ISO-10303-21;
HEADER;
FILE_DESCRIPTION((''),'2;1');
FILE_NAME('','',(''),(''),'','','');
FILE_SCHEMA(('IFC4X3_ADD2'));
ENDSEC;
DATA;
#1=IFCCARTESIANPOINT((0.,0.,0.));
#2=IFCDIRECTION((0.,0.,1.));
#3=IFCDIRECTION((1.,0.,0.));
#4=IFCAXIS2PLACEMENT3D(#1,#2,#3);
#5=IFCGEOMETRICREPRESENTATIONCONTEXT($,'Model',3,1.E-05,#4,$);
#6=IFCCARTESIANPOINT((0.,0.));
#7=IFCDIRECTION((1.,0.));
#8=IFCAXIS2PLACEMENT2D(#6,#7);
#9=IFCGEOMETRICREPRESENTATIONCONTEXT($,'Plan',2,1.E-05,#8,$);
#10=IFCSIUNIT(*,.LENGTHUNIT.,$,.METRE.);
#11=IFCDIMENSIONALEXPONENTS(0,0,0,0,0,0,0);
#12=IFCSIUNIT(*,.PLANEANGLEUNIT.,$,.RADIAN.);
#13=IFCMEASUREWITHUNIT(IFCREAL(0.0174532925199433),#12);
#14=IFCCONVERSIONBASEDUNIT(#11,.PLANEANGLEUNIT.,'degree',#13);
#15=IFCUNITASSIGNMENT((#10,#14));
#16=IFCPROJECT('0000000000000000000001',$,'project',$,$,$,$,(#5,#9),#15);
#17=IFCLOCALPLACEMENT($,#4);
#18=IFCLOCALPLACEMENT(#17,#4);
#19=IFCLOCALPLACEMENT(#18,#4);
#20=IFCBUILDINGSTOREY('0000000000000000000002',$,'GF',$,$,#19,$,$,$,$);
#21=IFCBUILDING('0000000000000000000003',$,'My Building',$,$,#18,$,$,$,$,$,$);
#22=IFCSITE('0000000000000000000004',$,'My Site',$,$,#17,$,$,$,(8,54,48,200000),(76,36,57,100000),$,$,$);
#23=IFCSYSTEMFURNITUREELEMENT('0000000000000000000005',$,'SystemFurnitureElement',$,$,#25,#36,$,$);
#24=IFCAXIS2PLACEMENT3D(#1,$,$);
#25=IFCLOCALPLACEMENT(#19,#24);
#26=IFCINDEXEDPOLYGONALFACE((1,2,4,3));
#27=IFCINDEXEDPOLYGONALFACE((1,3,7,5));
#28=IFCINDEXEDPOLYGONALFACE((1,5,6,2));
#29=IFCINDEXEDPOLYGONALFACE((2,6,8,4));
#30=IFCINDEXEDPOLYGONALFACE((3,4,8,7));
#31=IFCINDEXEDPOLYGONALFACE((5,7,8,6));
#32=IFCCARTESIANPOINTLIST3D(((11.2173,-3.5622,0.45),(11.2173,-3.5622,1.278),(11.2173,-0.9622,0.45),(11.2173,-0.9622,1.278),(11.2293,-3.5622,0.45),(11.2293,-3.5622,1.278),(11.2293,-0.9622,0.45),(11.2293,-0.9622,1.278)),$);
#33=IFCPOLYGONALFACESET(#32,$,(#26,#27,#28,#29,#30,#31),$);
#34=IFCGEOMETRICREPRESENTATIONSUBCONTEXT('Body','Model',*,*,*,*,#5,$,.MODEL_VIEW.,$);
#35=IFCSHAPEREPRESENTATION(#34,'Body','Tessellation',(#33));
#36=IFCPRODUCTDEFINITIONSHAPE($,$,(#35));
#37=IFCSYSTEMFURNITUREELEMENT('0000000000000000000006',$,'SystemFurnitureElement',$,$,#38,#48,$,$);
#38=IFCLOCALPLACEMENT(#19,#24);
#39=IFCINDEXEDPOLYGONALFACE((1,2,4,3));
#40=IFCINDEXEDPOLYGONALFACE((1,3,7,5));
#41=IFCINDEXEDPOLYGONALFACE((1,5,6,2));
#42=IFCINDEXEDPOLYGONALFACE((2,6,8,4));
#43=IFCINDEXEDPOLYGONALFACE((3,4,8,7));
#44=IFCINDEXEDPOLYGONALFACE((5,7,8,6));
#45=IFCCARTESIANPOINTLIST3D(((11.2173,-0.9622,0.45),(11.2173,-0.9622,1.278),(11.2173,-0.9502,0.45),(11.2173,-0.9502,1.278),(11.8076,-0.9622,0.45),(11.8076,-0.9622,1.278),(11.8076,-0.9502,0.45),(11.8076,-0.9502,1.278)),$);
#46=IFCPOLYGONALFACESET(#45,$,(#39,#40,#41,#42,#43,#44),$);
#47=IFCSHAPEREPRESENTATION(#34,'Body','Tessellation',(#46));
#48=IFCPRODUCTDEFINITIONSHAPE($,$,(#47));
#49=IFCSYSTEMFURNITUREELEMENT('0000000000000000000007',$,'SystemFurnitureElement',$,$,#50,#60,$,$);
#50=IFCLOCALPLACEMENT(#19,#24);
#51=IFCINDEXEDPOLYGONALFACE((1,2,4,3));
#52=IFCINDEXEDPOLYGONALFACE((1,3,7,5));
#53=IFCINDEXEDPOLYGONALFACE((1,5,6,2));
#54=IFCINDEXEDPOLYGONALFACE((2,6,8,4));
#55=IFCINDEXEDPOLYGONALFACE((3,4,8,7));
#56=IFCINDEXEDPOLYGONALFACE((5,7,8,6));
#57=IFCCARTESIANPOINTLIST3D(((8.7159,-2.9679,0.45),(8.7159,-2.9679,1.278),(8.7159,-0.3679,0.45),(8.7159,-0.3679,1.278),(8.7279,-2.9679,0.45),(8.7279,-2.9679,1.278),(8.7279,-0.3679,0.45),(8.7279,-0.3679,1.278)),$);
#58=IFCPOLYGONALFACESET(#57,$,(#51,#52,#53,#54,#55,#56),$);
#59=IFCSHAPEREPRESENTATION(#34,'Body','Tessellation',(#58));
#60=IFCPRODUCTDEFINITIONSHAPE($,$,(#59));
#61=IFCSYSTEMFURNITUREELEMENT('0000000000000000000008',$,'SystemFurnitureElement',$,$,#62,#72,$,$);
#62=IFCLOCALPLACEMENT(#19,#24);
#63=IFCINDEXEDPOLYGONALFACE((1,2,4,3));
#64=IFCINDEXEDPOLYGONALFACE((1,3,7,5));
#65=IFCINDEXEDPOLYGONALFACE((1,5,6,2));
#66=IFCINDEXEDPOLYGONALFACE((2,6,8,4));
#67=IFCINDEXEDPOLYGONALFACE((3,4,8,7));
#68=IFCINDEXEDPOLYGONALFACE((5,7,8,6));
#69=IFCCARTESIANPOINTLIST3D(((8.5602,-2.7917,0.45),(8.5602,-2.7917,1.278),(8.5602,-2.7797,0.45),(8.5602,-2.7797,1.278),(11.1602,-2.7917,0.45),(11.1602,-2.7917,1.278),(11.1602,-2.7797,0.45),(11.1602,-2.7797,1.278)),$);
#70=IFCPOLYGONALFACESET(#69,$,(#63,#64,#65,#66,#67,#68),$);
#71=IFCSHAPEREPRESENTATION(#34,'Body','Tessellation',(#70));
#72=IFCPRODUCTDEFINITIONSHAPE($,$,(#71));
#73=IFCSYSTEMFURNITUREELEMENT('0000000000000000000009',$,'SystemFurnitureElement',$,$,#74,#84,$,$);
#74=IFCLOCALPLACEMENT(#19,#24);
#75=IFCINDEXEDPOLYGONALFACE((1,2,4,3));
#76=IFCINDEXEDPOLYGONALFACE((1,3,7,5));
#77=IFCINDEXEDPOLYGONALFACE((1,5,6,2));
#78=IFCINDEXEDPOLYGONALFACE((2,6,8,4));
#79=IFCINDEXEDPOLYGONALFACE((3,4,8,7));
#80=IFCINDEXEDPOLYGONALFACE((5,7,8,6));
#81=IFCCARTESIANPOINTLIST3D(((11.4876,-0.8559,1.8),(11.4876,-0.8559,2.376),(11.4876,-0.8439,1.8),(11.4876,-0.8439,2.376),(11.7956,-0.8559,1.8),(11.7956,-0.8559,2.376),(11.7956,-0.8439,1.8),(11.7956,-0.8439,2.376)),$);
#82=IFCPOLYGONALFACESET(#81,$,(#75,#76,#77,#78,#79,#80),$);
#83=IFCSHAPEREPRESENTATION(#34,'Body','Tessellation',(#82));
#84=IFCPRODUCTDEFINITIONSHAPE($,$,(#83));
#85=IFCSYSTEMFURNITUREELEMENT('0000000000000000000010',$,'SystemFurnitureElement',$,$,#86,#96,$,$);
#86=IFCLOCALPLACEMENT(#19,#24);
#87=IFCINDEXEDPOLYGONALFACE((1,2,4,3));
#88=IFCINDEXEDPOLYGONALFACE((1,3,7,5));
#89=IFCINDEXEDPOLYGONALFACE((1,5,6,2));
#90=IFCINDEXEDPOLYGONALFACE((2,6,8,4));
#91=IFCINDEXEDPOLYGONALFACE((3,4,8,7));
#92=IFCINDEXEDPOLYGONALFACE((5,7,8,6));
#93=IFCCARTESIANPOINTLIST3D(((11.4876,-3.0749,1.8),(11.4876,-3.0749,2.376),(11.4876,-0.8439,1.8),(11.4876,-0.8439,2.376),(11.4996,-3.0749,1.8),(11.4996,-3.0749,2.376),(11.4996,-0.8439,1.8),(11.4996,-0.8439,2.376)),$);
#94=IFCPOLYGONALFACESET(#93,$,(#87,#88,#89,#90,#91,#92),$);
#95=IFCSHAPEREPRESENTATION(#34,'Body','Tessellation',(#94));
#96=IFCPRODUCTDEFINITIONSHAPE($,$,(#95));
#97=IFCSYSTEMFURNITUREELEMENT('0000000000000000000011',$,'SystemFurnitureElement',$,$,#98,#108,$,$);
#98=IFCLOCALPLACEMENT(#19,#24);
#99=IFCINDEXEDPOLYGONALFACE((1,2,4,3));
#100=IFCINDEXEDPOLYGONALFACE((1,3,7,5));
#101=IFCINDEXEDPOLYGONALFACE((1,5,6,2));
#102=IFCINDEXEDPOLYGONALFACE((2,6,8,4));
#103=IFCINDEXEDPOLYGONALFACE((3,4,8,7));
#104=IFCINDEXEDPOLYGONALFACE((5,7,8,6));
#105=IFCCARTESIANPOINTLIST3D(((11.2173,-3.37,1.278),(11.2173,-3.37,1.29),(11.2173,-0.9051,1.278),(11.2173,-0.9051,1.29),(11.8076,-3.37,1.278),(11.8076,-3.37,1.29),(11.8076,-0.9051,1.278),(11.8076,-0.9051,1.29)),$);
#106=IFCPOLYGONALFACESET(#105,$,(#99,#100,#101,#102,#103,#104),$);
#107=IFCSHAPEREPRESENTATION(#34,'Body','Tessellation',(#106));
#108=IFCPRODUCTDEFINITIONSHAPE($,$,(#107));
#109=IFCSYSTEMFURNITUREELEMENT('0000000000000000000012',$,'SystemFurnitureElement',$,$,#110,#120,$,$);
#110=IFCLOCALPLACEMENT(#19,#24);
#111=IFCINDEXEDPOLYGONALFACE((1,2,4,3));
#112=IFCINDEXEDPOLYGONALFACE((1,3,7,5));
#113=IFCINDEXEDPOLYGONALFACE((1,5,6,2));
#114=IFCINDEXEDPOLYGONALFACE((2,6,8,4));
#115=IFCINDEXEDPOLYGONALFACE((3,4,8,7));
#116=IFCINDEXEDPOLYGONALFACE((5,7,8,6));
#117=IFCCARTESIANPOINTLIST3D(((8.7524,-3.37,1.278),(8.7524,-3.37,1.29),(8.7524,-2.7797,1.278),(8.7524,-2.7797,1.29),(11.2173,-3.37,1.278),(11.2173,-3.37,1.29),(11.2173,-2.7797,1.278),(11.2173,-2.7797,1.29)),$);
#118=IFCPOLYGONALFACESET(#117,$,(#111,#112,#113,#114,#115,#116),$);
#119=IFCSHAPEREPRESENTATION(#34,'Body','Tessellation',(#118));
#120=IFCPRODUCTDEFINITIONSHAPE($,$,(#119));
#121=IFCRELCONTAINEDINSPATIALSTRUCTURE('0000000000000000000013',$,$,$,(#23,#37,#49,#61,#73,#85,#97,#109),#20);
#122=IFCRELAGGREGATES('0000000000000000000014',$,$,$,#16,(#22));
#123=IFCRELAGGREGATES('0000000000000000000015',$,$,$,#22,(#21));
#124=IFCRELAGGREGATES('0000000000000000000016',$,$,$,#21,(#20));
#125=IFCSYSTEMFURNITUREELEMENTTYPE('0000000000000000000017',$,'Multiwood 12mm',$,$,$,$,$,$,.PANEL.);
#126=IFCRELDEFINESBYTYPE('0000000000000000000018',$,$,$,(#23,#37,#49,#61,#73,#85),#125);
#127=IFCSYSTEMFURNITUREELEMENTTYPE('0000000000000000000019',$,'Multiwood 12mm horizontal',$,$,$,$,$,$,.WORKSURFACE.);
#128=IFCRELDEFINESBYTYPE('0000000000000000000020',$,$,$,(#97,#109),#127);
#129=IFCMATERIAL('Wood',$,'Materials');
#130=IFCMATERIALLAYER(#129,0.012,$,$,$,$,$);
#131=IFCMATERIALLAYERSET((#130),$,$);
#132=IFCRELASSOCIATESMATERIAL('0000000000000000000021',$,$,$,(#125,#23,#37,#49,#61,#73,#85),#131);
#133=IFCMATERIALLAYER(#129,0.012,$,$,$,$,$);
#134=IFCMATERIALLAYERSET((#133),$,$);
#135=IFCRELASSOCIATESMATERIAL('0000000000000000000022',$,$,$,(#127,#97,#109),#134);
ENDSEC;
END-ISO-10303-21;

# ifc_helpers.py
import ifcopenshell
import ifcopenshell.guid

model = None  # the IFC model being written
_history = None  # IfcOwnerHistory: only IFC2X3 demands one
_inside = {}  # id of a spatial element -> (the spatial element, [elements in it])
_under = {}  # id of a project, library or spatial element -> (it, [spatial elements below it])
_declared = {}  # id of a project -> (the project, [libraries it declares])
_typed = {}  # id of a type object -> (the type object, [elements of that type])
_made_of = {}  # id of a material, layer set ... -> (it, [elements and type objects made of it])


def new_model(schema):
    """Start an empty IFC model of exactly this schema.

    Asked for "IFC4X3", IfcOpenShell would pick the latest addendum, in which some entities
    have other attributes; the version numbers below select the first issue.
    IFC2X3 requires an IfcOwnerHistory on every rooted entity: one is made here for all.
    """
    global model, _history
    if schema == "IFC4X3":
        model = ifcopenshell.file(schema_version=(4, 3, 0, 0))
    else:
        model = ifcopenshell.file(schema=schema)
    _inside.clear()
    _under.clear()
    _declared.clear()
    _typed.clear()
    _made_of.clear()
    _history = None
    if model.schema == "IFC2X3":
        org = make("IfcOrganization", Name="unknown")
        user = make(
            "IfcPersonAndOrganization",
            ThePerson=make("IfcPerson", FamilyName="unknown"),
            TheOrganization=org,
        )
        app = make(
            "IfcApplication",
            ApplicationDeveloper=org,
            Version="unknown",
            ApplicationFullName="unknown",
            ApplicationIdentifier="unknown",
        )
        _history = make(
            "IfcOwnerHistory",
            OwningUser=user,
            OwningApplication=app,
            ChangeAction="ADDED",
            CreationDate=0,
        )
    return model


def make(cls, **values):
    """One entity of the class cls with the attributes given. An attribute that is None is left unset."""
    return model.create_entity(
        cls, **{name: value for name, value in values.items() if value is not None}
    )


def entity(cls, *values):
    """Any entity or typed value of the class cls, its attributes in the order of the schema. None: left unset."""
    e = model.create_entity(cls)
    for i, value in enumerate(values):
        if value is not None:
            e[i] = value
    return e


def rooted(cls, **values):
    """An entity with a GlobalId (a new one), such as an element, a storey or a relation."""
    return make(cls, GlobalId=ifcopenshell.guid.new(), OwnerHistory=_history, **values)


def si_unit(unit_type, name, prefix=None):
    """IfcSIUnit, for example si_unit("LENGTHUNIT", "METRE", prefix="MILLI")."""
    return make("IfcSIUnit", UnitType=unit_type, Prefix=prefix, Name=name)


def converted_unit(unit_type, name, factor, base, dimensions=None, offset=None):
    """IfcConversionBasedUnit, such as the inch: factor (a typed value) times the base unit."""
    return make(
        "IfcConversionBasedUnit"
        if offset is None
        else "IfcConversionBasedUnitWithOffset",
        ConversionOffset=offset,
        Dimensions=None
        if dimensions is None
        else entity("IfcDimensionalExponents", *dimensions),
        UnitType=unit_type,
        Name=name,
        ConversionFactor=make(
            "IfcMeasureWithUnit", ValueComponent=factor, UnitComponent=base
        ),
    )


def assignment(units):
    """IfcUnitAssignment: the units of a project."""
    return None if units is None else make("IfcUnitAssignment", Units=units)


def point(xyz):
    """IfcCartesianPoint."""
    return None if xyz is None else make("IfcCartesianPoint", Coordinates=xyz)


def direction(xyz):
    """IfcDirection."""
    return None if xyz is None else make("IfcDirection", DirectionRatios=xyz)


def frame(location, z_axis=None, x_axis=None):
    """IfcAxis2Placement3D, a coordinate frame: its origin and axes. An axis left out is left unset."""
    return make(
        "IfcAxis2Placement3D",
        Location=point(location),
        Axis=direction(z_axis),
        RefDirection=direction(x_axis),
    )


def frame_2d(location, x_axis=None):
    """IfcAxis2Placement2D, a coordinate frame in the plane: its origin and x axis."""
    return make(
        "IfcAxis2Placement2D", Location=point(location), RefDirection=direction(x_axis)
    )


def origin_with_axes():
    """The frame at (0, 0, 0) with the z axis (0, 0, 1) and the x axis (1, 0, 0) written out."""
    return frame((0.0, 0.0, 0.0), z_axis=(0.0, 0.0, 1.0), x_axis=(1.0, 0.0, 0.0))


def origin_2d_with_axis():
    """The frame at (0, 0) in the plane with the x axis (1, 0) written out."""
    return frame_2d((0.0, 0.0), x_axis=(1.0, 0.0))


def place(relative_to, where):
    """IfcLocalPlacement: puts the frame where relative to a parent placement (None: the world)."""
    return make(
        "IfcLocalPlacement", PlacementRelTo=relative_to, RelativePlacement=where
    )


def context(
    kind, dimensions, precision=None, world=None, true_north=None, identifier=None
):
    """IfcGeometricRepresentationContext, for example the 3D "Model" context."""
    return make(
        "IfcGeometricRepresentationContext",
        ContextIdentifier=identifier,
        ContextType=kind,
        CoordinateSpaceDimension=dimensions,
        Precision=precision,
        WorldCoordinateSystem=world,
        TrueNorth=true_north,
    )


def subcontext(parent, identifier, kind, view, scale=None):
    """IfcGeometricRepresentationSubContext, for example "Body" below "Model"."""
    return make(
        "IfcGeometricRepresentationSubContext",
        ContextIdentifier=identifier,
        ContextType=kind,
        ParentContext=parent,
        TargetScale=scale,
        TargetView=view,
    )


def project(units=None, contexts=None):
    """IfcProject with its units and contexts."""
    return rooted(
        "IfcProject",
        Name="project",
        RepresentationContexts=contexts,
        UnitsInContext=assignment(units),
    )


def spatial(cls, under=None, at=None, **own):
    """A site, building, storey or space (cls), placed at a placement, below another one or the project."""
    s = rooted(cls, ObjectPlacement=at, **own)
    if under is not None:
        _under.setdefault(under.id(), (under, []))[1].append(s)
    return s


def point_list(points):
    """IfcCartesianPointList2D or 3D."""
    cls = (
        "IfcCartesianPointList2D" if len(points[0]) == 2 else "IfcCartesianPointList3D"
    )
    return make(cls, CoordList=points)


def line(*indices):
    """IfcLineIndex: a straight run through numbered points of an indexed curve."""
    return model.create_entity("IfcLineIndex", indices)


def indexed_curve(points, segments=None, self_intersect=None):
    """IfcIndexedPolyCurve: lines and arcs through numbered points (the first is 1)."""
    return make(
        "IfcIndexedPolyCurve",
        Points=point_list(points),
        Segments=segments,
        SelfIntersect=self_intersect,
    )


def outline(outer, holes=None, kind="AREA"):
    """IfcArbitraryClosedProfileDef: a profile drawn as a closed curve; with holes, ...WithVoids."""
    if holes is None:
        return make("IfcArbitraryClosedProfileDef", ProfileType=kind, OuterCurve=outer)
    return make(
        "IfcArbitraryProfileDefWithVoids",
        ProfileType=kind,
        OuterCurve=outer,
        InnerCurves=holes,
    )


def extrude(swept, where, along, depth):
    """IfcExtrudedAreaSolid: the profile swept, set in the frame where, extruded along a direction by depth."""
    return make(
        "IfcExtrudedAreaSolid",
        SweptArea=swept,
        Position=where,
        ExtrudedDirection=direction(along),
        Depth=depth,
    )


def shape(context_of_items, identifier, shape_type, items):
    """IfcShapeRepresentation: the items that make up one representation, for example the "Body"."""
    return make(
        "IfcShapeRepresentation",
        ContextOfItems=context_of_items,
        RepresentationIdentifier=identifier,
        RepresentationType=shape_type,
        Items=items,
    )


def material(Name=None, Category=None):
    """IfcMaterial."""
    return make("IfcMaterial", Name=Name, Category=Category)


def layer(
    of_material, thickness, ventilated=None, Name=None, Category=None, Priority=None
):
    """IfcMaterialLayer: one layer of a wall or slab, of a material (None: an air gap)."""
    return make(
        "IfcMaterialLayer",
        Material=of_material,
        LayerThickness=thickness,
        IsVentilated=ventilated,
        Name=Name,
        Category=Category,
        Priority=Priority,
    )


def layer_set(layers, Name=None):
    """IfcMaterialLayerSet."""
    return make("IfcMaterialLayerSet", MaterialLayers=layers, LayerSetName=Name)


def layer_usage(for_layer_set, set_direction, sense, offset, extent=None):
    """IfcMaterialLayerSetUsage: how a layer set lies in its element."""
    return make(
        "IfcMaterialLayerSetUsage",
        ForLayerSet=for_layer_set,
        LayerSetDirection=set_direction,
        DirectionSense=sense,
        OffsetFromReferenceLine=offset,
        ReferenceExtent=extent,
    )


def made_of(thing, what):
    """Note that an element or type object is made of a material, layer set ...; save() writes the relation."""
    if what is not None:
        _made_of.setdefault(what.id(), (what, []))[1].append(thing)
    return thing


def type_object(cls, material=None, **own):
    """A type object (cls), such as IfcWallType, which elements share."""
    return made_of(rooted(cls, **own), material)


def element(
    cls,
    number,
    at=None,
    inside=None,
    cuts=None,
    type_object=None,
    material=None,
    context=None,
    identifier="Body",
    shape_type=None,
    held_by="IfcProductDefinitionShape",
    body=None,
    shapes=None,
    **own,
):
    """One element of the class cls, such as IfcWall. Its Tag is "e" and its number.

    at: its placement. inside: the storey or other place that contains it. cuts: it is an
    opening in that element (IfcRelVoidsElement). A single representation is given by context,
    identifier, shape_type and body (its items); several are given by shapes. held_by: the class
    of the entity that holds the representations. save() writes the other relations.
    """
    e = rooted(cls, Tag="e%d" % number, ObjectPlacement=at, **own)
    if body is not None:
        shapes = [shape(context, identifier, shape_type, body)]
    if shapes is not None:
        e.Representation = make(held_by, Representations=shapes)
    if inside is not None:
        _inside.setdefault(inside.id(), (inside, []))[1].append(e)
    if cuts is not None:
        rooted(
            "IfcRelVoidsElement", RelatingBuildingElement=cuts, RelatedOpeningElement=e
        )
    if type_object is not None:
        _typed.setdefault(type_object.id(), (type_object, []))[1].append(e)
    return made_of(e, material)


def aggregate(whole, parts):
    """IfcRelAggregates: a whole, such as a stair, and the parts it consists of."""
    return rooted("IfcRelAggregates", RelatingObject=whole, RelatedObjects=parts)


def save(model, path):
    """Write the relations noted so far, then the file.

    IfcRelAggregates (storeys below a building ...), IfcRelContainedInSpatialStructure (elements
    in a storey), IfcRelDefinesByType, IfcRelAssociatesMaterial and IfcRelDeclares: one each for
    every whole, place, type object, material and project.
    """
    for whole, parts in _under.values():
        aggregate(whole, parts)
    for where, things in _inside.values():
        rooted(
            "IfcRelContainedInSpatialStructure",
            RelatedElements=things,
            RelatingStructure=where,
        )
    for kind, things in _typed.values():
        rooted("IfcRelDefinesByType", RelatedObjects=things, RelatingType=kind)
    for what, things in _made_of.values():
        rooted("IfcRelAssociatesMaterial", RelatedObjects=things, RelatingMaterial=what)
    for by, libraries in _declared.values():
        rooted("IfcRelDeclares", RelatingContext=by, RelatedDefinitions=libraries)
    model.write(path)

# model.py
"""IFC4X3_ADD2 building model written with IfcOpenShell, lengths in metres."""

from ifc_helpers import new_model, entity, si_unit, converted_unit, frame, origin_with_axes, origin_2d_with_axis, place, context, subcontext, project, spatial, line, indexed_curve, outline, extrude, material, layer, layer_set, layer_usage, type_object, element, save


model = new_model("IFC4X3_ADD2")

# Units and contexts
model_context = context("Model", 3, precision=1e-05, world=origin_with_axes())
plan_context = context("Plan", 2, precision=1e-05, world=origin_2d_with_axis())
body_context = subcontext(model_context, "Body", "Model", "MODEL_VIEW")
ifc_project = project(units=[si_unit("LENGTHUNIT", "METRE"), converted_unit("PLANEANGLEUNIT", "degree", entity("IfcReal", 0.0174532925199433), si_unit("PLANEANGLEUNIT", "RADIAN"), dimensions=[0, 0, 0, 0, 0, 0, 0])], contexts=[model_context, plan_context])

# Site, building, storey
site_placement = place(None, origin_with_axes())
site = spatial("IfcSite", under=ifc_project, at=site_placement, Name="My Site", RefLatitude=(8, 54, 48, 200000), RefLongitude=(76, 36, 57, 100000))
building_placement = place(site_placement, origin_with_axes())
building = spatial("IfcBuilding", under=site, at=building_placement, Name="My Building")
storey_placement = place(building_placement, origin_with_axes())
storey = spatial("IfcBuildingStorey", under=building, at=storey_placement, Name="GF")

# System furniture elements
ifc_material_1 = material(Name="Wood", Category="Materials")
ifc_layer_1 = layer(ifc_material_1, 0.012)
ifc_layer_set_1 = layer_set([ifc_layer_1])
ifc_layer_usage_1 = layer_usage(ifc_layer_set_1, "AXIS2", "POSITIVE", 0.0)
system_furniture_element_type_1 = type_object("IfcSystemFurnitureElementType", Name="Multiwood 12mm", PredefinedType="PANEL", material=ifc_layer_set_1)
system_furniture_element_1_placement = place(storey_placement, frame((11.2173, -0.9622, 0.45), z_axis=(0.0, 0.0, 1.0), x_axis=(0.0, -1.0, 0.0)))
element("IfcSystemFurnitureElement", 1, at=system_furniture_element_1_placement, inside=storey, type_object=system_furniture_element_type_1, material=ifc_layer_usage_1, Name="SystemFurnitureElement", context=body_context, shape_type="SweptSolid", body=[
    extrude(outline(indexed_curve([(0.0, 0.0), (0.0, 0.012), (2.6, 0.012), (2.6, 0.0)], segments=[line(1, 2, 3, 4, 1)])), origin_with_axes(), (0.0, 0.0, 1.0), 0.828),
])
ifc_layer_usage_2 = layer_usage(ifc_layer_set_1, "AXIS2", "POSITIVE", 0.0)
system_furniture_element_2_placement = place(storey_placement, frame((11.2173, -0.9622, 0.45), z_axis=(0.0, 0.0, 1.0), x_axis=(1.0, 0.0, 0.0)))
element("IfcSystemFurnitureElement", 2, at=system_furniture_element_2_placement, inside=storey, type_object=system_furniture_element_type_1, material=ifc_layer_usage_2, Name="SystemFurnitureElement", context=body_context, shape_type="SweptSolid", body=[
    extrude(outline(indexed_curve([(0.0, 0.0), (0.0, 0.012), (0.5903, 0.012), (0.5903, 0.0)], segments=[line(1, 2, 3, 4, 1)])), origin_with_axes(), (0.0, 0.0, 1.0), 0.828),
])
ifc_layer_usage_3 = layer_usage(ifc_layer_set_1, "AXIS2", "POSITIVE", 0.0)
system_furniture_element_3_placement = place(storey_placement, frame((8.7159, -0.3679, 0.45), z_axis=(0.0, 0.0, 1.0), x_axis=(0.0, -1.0, 0.0)))
element("IfcSystemFurnitureElement", 3, at=system_furniture_element_3_placement, inside=storey, type_object=system_furniture_element_type_1, material=ifc_layer_usage_3, Name="SystemFurnitureElement", context=body_context, shape_type="SweptSolid", body=[
    extrude(outline(indexed_curve([(0.0, 0.0), (0.0, 0.012), (2.6, 0.012), (2.6, 0.0)], segments=[line(1, 2, 3, 4, 1)])), origin_with_axes(), (0.0, 0.0, 1.0), 0.828),
])
ifc_layer_usage_4 = layer_usage(ifc_layer_set_1, "AXIS2", "POSITIVE", 0.0)
system_furniture_element_4_placement = place(storey_placement, frame((11.1602, -2.7797, 0.45), z_axis=(0.0, 0.0, 1.0), x_axis=(-1.0, 0.0, 0.0)))
element("IfcSystemFurnitureElement", 4, at=system_furniture_element_4_placement, inside=storey, type_object=system_furniture_element_type_1, material=ifc_layer_usage_4, Name="SystemFurnitureElement", context=body_context, shape_type="SweptSolid", body=[
    extrude(outline(indexed_curve([(0.0, 0.0), (0.0, 0.012), (2.6, 0.012), (2.6, 0.0)], segments=[line(1, 2, 3, 4, 1)])), origin_with_axes(), (0.0, 0.0, 1.0), 0.828),
])
ifc_layer_usage_5 = layer_usage(ifc_layer_set_1, "AXIS2", "POSITIVE", 0.0)
system_furniture_element_5_placement = place(storey_placement, frame((11.7956, -0.8439, 1.8), z_axis=(0.0, 0.0, 1.0), x_axis=(-1.0, 0.0, 0.0)))
element("IfcSystemFurnitureElement", 5, at=system_furniture_element_5_placement, inside=storey, type_object=system_furniture_element_type_1, material=ifc_layer_usage_5, Name="SystemFurnitureElement", context=body_context, shape_type="SweptSolid", body=[
    extrude(outline(indexed_curve([(0.0, 0.0), (0.0, 0.012), (0.308, 0.012), (0.308, 0.0)], segments=[line(1, 2, 3, 4, 1)])), origin_with_axes(), (0.0, 0.0, 1.0), 0.576),
])
ifc_layer_usage_6 = layer_usage(ifc_layer_set_1, "AXIS2", "POSITIVE", 0.0)
system_furniture_element_6_placement = place(storey_placement, frame((11.4876, -0.8439, 1.8), z_axis=(0.0, 0.0, 1.0), x_axis=(0.0, -1.0, 0.0)))
element("IfcSystemFurnitureElement", 6, at=system_furniture_element_6_placement, inside=storey, type_object=system_furniture_element_type_1, material=ifc_layer_usage_6, Name="SystemFurnitureElement", context=body_context, shape_type="SweptSolid", body=[
    extrude(outline(indexed_curve([(0.0, 0.0), (0.0, 0.012), (2.2309, 0.012), (2.2309, 0.0)], segments=[line(1, 2, 3, 4, 1)])), origin_with_axes(), (0.0, 0.0, 1.0), 0.576),
])
ifc_layer_2 = layer(ifc_material_1, 0.012)
ifc_layer_set_2 = layer_set([ifc_layer_2])
ifc_layer_usage_7 = layer_usage(ifc_layer_set_2, "AXIS3", "POSITIVE", -0.012)
system_furniture_element_type_2 = type_object("IfcSystemFurnitureElementType", Name="Multiwood 12mm horizontal", PredefinedType="WORKSURFACE", material=ifc_layer_set_2)
system_furniture_element_7_placement = place(storey_placement, frame((11.8076, -0.9051, 1.29), z_axis=(0.0, 0.0, 1.0), x_axis=(1.0, 0.0, 0.0)))
element("IfcSystemFurnitureElement", 7, at=system_furniture_element_7_placement, inside=storey, type_object=system_furniture_element_type_2, material=ifc_layer_usage_7, Name="SystemFurnitureElement", context=body_context, shape_type="SweptSolid", body=[
    extrude(outline(indexed_curve([(0.0, -2.4649), (-0.5903, -2.4649), (-0.5903, 0.0), (0.0, 0.0), (0.0, -2.4649)])), frame((0.0, 0.0, -0.012), z_axis=(0.0, 0.0, 1.0), x_axis=(1.0, 0.0, 0.0)), (0.0, 0.0, 1.0), 0.012),
])
ifc_layer_usage_8 = layer_usage(ifc_layer_set_2, "AXIS3", "POSITIVE", -0.012)
system_furniture_element_8_placement = place(storey_placement, frame((11.2173, -3.37, 1.29), z_axis=(0.0, 0.0, 1.0), x_axis=(0.0, -1.0, 0.0)))
element("IfcSystemFurnitureElement", 8, at=system_furniture_element_8_placement, inside=storey, type_object=system_furniture_element_type_2, material=ifc_layer_usage_8, Name="SystemFurnitureElement", context=body_context, shape_type="SweptSolid", body=[
    extrude(outline(indexed_curve([(0.0, -2.4649), (-0.5903, -2.4649), (-0.5903, 0.0), (0.0, 0.0), (0.0, -2.4649)])), frame((0.0, 0.0, -0.012), z_axis=(0.0, 0.0, 1.0), x_axis=(1.0, 0.0, 0.0)), (0.0, 0.0, 1.0), 0.012),
])

save(model, "model.ifc")
